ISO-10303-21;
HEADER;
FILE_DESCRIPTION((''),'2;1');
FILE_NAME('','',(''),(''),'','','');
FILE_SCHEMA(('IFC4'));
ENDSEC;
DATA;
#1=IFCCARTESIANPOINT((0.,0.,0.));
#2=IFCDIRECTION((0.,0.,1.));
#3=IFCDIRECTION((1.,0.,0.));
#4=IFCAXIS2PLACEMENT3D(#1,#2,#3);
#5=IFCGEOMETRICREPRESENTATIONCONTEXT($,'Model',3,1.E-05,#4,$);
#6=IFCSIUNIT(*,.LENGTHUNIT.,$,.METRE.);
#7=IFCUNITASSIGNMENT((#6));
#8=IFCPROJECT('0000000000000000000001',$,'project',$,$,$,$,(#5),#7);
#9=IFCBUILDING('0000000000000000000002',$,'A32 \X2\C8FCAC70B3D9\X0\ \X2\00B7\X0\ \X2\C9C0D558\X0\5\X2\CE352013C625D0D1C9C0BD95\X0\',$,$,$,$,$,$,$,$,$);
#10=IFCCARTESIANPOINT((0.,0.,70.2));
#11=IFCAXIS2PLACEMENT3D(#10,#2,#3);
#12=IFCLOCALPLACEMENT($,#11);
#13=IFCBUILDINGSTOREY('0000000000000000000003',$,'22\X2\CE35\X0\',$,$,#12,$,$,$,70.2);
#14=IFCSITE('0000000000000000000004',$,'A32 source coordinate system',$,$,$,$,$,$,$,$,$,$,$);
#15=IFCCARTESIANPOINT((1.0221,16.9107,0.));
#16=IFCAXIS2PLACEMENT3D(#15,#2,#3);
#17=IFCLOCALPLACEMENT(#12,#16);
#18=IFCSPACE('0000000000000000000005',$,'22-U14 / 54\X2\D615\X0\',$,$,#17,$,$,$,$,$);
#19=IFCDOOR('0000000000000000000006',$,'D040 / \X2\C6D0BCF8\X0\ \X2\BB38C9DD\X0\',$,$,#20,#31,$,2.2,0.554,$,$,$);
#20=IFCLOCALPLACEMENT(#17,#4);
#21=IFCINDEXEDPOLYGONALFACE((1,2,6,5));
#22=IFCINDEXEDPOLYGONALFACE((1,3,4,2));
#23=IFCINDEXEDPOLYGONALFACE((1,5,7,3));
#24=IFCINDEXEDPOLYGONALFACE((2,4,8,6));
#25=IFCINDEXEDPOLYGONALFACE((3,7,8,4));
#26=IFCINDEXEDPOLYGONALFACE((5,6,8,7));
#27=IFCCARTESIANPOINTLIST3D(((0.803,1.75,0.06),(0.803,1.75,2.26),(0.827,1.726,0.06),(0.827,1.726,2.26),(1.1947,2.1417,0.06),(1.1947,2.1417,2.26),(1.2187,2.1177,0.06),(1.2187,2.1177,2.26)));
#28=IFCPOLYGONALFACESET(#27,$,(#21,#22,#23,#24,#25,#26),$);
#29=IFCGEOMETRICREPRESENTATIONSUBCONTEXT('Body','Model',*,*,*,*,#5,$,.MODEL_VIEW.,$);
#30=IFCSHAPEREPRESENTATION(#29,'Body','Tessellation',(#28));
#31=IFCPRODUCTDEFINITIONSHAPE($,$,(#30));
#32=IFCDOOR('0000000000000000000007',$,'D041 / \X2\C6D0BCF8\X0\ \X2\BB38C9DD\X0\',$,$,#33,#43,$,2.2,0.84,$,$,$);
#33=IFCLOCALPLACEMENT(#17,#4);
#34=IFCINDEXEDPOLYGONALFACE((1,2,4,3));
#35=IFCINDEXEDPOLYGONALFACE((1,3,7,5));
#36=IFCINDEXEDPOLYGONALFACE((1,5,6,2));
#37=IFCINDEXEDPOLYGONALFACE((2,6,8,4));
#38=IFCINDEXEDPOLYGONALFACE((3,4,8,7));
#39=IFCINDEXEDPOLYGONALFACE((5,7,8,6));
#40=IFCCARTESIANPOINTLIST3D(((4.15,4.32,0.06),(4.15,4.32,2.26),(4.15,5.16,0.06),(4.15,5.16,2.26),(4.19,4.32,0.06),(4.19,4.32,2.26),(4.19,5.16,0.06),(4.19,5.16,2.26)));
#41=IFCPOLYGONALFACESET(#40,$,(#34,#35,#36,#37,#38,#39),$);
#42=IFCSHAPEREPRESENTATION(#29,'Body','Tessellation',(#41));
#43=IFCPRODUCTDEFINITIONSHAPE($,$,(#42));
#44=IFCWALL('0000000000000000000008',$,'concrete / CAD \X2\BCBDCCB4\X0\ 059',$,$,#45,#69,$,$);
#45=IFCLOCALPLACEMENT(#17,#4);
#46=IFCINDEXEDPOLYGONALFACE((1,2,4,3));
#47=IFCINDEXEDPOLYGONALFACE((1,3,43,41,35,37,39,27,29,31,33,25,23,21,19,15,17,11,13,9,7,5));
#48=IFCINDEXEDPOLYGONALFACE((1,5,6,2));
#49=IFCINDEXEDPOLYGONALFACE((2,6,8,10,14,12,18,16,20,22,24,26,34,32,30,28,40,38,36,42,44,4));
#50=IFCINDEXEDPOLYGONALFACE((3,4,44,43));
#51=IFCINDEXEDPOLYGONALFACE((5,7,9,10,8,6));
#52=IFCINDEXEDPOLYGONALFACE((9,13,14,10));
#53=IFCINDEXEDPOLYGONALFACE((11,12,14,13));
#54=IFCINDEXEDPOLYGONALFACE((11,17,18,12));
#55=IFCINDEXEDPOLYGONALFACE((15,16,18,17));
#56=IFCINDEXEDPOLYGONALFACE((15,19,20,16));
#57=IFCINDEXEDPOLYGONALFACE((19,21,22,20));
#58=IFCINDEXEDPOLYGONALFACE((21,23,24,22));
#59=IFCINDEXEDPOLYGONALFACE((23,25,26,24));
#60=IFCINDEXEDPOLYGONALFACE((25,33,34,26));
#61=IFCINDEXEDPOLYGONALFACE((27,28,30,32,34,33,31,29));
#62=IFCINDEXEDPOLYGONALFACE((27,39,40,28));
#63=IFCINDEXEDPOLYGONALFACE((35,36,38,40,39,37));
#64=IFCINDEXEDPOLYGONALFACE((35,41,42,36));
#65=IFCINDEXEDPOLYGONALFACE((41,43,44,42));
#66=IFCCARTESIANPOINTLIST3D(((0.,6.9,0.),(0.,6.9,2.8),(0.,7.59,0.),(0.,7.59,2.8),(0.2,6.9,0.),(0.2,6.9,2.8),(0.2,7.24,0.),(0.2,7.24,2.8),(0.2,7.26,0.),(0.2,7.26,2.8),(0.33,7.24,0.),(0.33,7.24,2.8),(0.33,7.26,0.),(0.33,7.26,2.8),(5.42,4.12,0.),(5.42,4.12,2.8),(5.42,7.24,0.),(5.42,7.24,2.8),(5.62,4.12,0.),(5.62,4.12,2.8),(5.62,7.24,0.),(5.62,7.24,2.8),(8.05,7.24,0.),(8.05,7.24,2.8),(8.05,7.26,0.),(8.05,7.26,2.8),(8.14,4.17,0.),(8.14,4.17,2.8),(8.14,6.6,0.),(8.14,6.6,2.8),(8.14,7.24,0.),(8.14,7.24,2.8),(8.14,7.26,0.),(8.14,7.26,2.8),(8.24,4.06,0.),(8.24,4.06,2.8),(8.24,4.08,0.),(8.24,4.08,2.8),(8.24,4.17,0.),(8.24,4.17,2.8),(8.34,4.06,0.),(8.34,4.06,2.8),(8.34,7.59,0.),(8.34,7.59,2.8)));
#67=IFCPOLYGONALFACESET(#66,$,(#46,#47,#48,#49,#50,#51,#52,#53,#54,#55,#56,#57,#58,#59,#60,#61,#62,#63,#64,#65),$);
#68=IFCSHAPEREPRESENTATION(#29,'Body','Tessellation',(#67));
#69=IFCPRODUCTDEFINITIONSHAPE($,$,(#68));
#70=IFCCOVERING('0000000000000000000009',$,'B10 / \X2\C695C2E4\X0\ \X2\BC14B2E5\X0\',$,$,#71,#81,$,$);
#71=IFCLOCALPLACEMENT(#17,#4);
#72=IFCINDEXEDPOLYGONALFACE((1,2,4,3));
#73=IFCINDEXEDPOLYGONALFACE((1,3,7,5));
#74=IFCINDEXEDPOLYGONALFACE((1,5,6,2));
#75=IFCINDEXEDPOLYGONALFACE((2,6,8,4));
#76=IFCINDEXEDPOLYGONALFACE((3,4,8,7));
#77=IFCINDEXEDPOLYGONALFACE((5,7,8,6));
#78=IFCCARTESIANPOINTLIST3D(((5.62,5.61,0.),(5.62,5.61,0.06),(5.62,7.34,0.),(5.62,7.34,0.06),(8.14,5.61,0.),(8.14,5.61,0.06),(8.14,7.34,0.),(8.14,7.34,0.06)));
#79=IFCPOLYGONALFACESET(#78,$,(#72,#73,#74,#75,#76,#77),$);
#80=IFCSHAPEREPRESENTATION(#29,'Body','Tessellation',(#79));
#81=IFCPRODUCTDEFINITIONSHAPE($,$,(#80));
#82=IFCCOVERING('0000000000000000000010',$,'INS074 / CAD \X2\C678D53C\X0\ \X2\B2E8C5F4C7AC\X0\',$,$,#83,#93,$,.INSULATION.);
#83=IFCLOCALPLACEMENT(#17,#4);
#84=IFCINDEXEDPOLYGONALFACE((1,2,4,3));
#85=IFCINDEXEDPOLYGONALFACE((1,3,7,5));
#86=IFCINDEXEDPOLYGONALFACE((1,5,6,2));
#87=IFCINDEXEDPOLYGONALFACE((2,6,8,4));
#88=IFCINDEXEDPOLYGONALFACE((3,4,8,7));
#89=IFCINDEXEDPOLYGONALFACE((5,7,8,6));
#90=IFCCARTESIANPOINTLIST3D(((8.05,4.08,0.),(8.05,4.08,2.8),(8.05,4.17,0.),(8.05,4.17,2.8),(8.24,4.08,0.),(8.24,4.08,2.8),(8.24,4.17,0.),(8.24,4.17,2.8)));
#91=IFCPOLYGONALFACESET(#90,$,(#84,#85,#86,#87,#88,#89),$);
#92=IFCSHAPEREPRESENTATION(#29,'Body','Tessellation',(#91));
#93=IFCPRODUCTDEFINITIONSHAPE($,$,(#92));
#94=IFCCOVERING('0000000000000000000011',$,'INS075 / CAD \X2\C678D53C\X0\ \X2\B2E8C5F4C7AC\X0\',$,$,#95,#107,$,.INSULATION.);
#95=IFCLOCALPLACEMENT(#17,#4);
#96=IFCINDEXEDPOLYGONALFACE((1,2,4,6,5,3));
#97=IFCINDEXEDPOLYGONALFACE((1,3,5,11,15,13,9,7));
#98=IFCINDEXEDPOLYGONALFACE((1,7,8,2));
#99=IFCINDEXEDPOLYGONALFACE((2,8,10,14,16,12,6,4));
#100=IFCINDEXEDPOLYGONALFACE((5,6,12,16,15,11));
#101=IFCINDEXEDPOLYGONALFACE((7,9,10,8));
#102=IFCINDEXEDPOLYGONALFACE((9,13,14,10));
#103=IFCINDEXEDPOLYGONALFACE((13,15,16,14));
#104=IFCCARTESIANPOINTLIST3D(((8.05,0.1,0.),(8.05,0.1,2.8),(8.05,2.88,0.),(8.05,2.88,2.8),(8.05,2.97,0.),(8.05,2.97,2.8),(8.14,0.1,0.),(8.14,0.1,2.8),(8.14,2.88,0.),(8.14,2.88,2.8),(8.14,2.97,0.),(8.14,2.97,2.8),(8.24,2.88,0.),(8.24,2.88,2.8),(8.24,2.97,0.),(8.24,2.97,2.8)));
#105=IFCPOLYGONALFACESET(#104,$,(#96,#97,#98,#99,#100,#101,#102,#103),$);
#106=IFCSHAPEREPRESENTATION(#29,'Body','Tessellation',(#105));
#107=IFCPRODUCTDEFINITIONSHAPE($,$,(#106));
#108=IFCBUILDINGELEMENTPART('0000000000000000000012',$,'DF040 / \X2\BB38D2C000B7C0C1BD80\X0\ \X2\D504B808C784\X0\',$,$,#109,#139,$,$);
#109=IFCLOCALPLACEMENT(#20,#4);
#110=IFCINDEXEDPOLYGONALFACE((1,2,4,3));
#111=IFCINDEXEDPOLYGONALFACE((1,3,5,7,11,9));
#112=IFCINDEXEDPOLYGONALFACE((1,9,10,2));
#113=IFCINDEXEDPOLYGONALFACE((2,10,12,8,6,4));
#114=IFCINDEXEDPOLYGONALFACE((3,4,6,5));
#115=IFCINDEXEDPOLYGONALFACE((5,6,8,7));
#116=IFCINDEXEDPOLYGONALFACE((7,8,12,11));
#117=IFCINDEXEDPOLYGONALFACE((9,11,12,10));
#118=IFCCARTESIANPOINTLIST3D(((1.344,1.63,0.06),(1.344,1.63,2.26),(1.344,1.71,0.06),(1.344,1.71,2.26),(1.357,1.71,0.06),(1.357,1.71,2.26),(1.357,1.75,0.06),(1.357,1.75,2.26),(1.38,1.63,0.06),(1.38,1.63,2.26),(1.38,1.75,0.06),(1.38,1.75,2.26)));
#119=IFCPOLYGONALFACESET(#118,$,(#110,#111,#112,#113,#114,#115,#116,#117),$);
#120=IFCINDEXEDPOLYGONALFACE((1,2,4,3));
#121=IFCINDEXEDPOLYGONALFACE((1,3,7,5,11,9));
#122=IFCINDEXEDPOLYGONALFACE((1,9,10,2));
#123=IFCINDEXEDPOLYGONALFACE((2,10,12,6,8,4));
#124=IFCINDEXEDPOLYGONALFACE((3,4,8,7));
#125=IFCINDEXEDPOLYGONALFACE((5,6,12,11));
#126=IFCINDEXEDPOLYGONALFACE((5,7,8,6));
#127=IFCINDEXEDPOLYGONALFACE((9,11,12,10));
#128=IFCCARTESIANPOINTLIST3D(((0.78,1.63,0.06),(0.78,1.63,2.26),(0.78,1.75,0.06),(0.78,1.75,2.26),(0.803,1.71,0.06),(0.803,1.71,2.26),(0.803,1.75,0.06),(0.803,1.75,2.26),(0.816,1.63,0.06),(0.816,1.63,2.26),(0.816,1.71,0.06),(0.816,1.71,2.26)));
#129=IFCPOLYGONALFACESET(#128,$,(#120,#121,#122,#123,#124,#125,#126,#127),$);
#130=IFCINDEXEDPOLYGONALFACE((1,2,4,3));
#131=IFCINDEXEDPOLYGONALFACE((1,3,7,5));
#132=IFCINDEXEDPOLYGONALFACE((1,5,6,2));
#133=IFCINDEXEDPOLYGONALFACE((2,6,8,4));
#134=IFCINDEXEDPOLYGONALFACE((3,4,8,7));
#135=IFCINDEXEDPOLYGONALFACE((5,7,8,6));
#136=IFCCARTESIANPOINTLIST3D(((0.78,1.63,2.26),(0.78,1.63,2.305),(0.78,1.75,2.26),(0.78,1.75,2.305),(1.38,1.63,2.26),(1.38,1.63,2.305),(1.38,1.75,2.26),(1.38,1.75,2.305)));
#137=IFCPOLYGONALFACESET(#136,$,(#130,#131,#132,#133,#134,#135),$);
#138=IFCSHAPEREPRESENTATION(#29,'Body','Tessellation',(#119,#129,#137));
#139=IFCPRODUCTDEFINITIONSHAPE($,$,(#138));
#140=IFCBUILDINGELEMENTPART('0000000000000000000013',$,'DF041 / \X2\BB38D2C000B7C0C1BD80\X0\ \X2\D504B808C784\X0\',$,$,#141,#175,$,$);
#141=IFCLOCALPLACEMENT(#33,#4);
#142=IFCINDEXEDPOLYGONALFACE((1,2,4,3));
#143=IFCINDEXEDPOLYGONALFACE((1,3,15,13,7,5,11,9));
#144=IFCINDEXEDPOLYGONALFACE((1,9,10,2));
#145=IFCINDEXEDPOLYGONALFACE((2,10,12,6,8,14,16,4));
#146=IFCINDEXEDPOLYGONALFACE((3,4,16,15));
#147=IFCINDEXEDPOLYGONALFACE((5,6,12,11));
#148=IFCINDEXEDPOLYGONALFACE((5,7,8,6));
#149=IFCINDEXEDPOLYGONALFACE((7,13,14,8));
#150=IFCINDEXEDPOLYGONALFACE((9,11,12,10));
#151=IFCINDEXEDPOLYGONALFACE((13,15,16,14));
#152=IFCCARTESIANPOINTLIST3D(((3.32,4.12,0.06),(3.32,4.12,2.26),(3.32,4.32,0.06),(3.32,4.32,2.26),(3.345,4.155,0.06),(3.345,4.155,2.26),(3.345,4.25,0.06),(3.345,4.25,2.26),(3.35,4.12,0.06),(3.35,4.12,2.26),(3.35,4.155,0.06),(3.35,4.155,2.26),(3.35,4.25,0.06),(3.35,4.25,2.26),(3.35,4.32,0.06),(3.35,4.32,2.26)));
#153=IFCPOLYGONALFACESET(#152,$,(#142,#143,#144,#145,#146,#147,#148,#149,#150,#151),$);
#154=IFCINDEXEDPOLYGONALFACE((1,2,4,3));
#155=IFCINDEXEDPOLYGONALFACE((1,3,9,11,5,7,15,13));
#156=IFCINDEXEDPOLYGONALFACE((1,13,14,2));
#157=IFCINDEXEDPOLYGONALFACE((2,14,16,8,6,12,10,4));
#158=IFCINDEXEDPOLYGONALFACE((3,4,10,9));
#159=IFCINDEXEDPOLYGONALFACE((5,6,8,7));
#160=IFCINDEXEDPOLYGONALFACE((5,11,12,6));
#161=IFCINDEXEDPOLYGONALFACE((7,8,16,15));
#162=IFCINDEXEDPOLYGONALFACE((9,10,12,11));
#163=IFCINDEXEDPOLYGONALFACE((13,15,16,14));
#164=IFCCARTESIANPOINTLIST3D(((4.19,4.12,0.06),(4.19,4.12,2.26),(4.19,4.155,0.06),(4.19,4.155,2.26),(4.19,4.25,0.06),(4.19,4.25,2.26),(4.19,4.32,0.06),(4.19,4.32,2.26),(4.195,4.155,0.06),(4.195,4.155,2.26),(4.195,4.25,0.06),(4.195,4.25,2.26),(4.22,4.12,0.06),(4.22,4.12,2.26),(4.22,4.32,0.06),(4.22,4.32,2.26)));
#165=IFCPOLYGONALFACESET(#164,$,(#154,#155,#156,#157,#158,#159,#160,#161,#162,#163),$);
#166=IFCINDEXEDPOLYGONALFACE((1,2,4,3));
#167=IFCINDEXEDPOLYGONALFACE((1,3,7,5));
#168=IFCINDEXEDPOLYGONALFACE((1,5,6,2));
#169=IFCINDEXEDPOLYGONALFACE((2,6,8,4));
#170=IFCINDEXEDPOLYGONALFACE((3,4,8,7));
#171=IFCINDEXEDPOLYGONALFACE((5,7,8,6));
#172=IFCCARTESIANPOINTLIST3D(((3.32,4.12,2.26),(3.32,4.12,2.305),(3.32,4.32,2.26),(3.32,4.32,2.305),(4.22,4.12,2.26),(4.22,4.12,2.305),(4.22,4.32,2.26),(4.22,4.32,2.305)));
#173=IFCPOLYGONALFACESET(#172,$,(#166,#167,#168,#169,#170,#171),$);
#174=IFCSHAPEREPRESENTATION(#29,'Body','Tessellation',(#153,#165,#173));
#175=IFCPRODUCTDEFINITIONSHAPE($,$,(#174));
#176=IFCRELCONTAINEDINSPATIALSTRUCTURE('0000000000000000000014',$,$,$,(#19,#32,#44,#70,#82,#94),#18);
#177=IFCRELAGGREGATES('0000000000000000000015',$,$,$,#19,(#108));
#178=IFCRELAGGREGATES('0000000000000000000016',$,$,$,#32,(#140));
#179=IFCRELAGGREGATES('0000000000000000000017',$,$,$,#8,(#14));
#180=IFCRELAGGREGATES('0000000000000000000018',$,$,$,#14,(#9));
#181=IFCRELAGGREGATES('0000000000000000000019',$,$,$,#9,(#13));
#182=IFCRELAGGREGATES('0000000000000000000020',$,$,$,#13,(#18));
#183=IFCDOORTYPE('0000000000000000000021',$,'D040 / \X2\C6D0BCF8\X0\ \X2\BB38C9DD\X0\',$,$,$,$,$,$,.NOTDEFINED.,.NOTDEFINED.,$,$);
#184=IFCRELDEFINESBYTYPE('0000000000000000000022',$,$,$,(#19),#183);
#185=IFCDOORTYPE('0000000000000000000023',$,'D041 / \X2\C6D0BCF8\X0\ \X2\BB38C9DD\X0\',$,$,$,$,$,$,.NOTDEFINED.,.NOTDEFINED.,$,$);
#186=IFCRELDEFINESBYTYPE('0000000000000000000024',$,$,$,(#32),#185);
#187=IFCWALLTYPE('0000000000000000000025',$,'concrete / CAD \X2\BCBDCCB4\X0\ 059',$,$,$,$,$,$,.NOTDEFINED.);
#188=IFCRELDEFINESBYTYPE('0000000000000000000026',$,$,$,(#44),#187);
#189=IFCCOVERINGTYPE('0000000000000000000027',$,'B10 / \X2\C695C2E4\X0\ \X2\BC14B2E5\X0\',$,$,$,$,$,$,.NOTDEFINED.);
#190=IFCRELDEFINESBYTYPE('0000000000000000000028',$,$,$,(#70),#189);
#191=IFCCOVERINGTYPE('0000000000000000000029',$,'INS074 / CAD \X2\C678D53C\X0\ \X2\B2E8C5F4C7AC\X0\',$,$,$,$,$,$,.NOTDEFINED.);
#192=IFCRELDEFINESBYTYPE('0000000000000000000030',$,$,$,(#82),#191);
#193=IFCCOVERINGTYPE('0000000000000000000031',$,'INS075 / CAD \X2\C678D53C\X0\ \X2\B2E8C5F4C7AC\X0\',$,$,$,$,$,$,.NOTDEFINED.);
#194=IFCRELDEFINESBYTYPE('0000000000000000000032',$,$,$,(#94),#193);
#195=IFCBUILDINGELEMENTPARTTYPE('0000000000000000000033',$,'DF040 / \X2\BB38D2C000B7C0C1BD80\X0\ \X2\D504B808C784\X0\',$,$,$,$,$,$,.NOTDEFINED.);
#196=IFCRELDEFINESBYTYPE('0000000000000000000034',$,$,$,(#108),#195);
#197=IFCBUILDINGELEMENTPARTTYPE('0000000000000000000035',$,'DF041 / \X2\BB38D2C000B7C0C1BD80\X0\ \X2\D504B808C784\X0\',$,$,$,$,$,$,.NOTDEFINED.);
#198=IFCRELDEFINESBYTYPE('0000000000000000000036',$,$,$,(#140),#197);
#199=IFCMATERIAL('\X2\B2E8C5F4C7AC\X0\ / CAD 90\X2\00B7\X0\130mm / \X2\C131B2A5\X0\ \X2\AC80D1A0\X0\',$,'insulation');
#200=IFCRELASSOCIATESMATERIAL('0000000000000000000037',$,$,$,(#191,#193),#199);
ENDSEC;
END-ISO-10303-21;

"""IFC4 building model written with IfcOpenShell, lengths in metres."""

from ifc_helpers import new_model, si_unit, frame, origin, origin_with_axes, place, context, subcontext, project, spatial, polyline, outline, extrude, source, transform, mapped, material, type_object, type_shapes, element, aggregate, save


model = new_model("IFC4")

# Units and contexts
model_context = context("Model", 3, precision=1e-05, world=origin_with_axes())
body_context = subcontext(model_context, "Body", "Model", "MODEL_VIEW")
ifc_project = project(units=[si_unit("LENGTHUNIT", "METRE")], contexts=[model_context])

# Site, building, storey, space
storey_placement = place(None, frame((0.0, 0.0, 70.2), z_axis=(0.0, 0.0, 1.0), x_axis=(1.0, 0.0, 0.0)))
space_1_placement = place(storey_placement, frame((1.0221, 16.9107, 0.0), z_axis=(0.0, 0.0, 1.0), x_axis=(1.0, 0.0, 0.0)))
site = spatial("IfcSite", under=ifc_project, Name="A32 source coordinate system")
building = spatial("IfcBuilding", under=site, Name="A32 주거동 · 지하5층–옥탑지붕")
storey = spatial("IfcBuildingStorey", under=building, at=storey_placement, Name="22층", Elevation=70.2)
space_1 = spatial("IfcSpace", under=storey, at=space_1_placement, Name="22-U14 / 54형")

# Doors
door_type_1 = type_object("IfcDoorType", Name="D040 / 원본 문짝", OperationType="NOTDEFINED", PredefinedType="NOTDEFINED")
shared_shape_1 = source(origin(), body_context, "Body", "SweptSolid", [
    extrude(outline(polyline([(0.803, 1.75), (1.1947, 2.1417), (1.2187, 2.1177), (0.827, 1.726), (0.803, 1.75)])), frame((0.0, 0.0, 0.06)), (0.0, 0.0, 1.0), 2.2),
])
type_shapes(door_type_1, [shared_shape_1])
door_1_placement = place(space_1_placement, origin_with_axes())
door_1 = element("IfcDoor", 1, at=door_1_placement, inside=space_1, type_object=door_type_1, Name="D040 / 원본 문짝", OverallHeight=2.2, OverallWidth=0.554, context=body_context, shape_type="MappedRepresentation", body=[
    mapped(shared_shape_1, transform((0.0, 0.0, 0.0), scale=1.0)),
])
door_type_2 = type_object("IfcDoorType", Name="D041 / 원본 문짝", OperationType="NOTDEFINED", PredefinedType="NOTDEFINED")
shared_shape_2 = source(origin(), body_context, "Body", "SweptSolid", [
    extrude(outline(polyline([(4.15, 5.16), (4.19, 5.16), (4.19, 4.32), (4.15, 4.32), (4.15, 5.16)])), frame((0.0, 0.0, 0.06)), (0.0, 0.0, 1.0), 2.2),
])
type_shapes(door_type_2, [shared_shape_2])
door_2_placement = place(space_1_placement, origin_with_axes())
door_2 = element("IfcDoor", 2, at=door_2_placement, inside=space_1, type_object=door_type_2, Name="D041 / 원본 문짝", OverallHeight=2.2, OverallWidth=0.84, context=body_context, shape_type="MappedRepresentation", body=[
    mapped(shared_shape_2, transform((0.0, 0.0, 0.0), scale=1.0)),
])

# Wall
wall_type_1 = type_object("IfcWallType", Name="concrete / CAD 벽체 059", PredefinedType="NOTDEFINED")
shared_shape_3 = source(origin(), body_context, "Body", "SweptSolid", [
    extrude(outline(polyline([(8.05, 7.26), (8.05, 7.24), (5.62, 7.24), (5.62, 4.12), (5.42, 4.12), (5.42, 7.24), (0.33, 7.24), (0.33, 7.26), (0.2, 7.26), (0.2, 7.24), (0.2, 6.9), (0.0, 6.9), (0.0, 7.59), (8.34, 7.59), (8.34, 4.06), (8.24, 4.06), (8.24, 4.08), (8.24, 4.17), (8.14, 4.17), (8.14, 6.6), (8.14, 7.24), (8.14, 7.26), (8.05, 7.26)])), origin(), (0.0, 0.0, 1.0), 2.8),
])
type_shapes(wall_type_1, [shared_shape_3])
wall_1_placement = place(space_1_placement, origin_with_axes())
element("IfcWall", 3, at=wall_1_placement, inside=space_1, type_object=wall_type_1, Name="concrete / CAD 벽체 059", context=body_context, shape_type="MappedRepresentation", body=[
    mapped(shared_shape_3, transform((0.0, 0.0, 0.0), scale=1.0)),
])

# Coverings
covering_type_1 = type_object("IfcCoveringType", Name="B10 / 욕실 바닥", PredefinedType="NOTDEFINED")
shared_shape_4 = source(origin(), body_context, "Body", "SweptSolid", [
    extrude(outline(polyline([(8.14, 5.61), (5.62, 5.61), (5.62, 7.34), (8.14, 7.34), (8.14, 5.61)])), origin(), (0.0, 0.0, 1.0), 0.06),
])
type_shapes(covering_type_1, [shared_shape_4])
covering_1_placement = place(space_1_placement, origin_with_axes())
element("IfcCovering", 4, at=covering_1_placement, inside=space_1, type_object=covering_type_1, Name="B10 / 욕실 바닥", context=body_context, shape_type="MappedRepresentation", body=[
    mapped(shared_shape_4, transform((0.0, 0.0, 0.0), scale=1.0)),
])
ifc_material = material(Name="단열재 / CAD 90·130mm / 성능 검토", Category="insulation")
covering_type_2 = type_object("IfcCoveringType", Name="INS074 / CAD 외피 단열재", PredefinedType="NOTDEFINED", material=ifc_material)
shared_shape_5 = source(origin(), body_context, "Body", "SweptSolid", [
    extrude(outline(polyline([(8.05, 4.08), (8.05, 4.17), (8.24, 4.17), (8.24, 4.08), (8.05, 4.08)])), origin(), (0.0, 0.0, 1.0), 2.8),
])
type_shapes(covering_type_2, [shared_shape_5])
covering_2_placement = place(space_1_placement, origin_with_axes())
element("IfcCovering", 5, at=covering_2_placement, inside=space_1, type_object=covering_type_2, Name="INS074 / CAD 외피 단열재", PredefinedType="INSULATION", context=body_context, shape_type="MappedRepresentation", body=[
    mapped(shared_shape_5, transform((0.0, 0.0, 0.0), scale=1.0)),
])
covering_type_3 = type_object("IfcCoveringType", Name="INS075 / CAD 외피 단열재", PredefinedType="NOTDEFINED", material=ifc_material)
shared_shape_6 = source(origin(), body_context, "Body", "SweptSolid", [
    extrude(outline(polyline([(8.24, 2.88), (8.14, 2.88), (8.14, 0.1), (8.05, 0.1), (8.05, 2.88), (8.05, 2.97), (8.14, 2.97), (8.24, 2.97), (8.24, 2.88)])), origin(), (0.0, 0.0, 1.0), 2.8),
])
type_shapes(covering_type_3, [shared_shape_6])
covering_3_placement = place(space_1_placement, origin_with_axes())
element("IfcCovering", 6, at=covering_3_placement, inside=space_1, type_object=covering_type_3, Name="INS075 / CAD 외피 단열재", PredefinedType="INSULATION", context=body_context, shape_type="MappedRepresentation", body=[
    mapped(shared_shape_6, transform((0.0, 0.0, 0.0), scale=1.0)),
])

# Building element parts
building_element_part_type_1 = type_object("IfcBuildingElementPartType", Name="DF040 / 문틀·상부 프레임", PredefinedType="NOTDEFINED")
shared_shape_7 = source(origin(), body_context, "Body", "SweptSolid", [
    extrude(outline(polyline([(1.344, 1.63), (1.344, 1.71), (1.357, 1.71), (1.357, 1.75), (1.38, 1.75), (1.38, 1.63), (1.344, 1.63)])), frame((0.0, 0.0, 0.06)), (0.0, 0.0, 1.0), 2.2),
    extrude(outline(polyline([(0.78, 1.75), (0.803, 1.75), (0.803, 1.71), (0.816, 1.71), (0.816, 1.63), (0.78, 1.63), (0.78, 1.75)])), frame((0.0, 0.0, 0.06)), (0.0, 0.0, 1.0), 2.2),
    extrude(outline(polyline([(0.78, 1.63), (0.78, 1.75), (1.38, 1.75), (1.38, 1.63), (0.78, 1.63)])), frame((0.0, 0.0, 2.26)), (0.0, 0.0, 1.0), 0.045),
])
type_shapes(building_element_part_type_1, [shared_shape_7])
building_element_part_1_placement = place(door_1_placement, origin_with_axes())
building_element_part_1 = element("IfcBuildingElementPart", 7, at=building_element_part_1_placement, type_object=building_element_part_type_1, Name="DF040 / 문틀·상부 프레임", context=body_context, shape_type="MappedRepresentation", body=[
    mapped(shared_shape_7, transform((0.0, 0.0, 0.0), scale=1.0)),
])
aggregate(door_1, [building_element_part_1])
building_element_part_type_2 = type_object("IfcBuildingElementPartType", Name="DF041 / 문틀·상부 프레임", PredefinedType="NOTDEFINED")
shared_shape_8 = source(origin(), body_context, "Body", "SweptSolid", [
    extrude(outline(polyline([(3.35, 4.32), (3.35, 4.25), (3.345, 4.25), (3.345, 4.155), (3.35, 4.155), (3.35, 4.12), (3.32, 4.12), (3.32, 4.32), (3.35, 4.32)])), frame((0.0, 0.0, 0.06)), (0.0, 0.0, 1.0), 2.2),
    extrude(outline(polyline([(4.22, 4.12), (4.19, 4.12), (4.19, 4.155), (4.195, 4.155), (4.195, 4.25), (4.19, 4.25), (4.19, 4.32), (4.22, 4.32), (4.22, 4.12)])), frame((0.0, 0.0, 0.06)), (0.0, 0.0, 1.0), 2.2),
    extrude(outline(polyline([(3.32, 4.12), (3.32, 4.32), (4.22, 4.32), (4.22, 4.12), (3.32, 4.12)])), frame((0.0, 0.0, 2.26)), (0.0, 0.0, 1.0), 0.045),
])
type_shapes(building_element_part_type_2, [shared_shape_8])
building_element_part_2_placement = place(door_2_placement, origin_with_axes())
building_element_part_2 = element("IfcBuildingElementPart", 8, at=building_element_part_2_placement, type_object=building_element_part_type_2, Name="DF041 / 문틀·상부 프레임", context=body_context, shape_type="MappedRepresentation", body=[
    mapped(shared_shape_8, transform((0.0, 0.0, 0.0), scale=1.0)),
])
aggregate(door_2, [building_element_part_2])

save(model, "model.ifc")
